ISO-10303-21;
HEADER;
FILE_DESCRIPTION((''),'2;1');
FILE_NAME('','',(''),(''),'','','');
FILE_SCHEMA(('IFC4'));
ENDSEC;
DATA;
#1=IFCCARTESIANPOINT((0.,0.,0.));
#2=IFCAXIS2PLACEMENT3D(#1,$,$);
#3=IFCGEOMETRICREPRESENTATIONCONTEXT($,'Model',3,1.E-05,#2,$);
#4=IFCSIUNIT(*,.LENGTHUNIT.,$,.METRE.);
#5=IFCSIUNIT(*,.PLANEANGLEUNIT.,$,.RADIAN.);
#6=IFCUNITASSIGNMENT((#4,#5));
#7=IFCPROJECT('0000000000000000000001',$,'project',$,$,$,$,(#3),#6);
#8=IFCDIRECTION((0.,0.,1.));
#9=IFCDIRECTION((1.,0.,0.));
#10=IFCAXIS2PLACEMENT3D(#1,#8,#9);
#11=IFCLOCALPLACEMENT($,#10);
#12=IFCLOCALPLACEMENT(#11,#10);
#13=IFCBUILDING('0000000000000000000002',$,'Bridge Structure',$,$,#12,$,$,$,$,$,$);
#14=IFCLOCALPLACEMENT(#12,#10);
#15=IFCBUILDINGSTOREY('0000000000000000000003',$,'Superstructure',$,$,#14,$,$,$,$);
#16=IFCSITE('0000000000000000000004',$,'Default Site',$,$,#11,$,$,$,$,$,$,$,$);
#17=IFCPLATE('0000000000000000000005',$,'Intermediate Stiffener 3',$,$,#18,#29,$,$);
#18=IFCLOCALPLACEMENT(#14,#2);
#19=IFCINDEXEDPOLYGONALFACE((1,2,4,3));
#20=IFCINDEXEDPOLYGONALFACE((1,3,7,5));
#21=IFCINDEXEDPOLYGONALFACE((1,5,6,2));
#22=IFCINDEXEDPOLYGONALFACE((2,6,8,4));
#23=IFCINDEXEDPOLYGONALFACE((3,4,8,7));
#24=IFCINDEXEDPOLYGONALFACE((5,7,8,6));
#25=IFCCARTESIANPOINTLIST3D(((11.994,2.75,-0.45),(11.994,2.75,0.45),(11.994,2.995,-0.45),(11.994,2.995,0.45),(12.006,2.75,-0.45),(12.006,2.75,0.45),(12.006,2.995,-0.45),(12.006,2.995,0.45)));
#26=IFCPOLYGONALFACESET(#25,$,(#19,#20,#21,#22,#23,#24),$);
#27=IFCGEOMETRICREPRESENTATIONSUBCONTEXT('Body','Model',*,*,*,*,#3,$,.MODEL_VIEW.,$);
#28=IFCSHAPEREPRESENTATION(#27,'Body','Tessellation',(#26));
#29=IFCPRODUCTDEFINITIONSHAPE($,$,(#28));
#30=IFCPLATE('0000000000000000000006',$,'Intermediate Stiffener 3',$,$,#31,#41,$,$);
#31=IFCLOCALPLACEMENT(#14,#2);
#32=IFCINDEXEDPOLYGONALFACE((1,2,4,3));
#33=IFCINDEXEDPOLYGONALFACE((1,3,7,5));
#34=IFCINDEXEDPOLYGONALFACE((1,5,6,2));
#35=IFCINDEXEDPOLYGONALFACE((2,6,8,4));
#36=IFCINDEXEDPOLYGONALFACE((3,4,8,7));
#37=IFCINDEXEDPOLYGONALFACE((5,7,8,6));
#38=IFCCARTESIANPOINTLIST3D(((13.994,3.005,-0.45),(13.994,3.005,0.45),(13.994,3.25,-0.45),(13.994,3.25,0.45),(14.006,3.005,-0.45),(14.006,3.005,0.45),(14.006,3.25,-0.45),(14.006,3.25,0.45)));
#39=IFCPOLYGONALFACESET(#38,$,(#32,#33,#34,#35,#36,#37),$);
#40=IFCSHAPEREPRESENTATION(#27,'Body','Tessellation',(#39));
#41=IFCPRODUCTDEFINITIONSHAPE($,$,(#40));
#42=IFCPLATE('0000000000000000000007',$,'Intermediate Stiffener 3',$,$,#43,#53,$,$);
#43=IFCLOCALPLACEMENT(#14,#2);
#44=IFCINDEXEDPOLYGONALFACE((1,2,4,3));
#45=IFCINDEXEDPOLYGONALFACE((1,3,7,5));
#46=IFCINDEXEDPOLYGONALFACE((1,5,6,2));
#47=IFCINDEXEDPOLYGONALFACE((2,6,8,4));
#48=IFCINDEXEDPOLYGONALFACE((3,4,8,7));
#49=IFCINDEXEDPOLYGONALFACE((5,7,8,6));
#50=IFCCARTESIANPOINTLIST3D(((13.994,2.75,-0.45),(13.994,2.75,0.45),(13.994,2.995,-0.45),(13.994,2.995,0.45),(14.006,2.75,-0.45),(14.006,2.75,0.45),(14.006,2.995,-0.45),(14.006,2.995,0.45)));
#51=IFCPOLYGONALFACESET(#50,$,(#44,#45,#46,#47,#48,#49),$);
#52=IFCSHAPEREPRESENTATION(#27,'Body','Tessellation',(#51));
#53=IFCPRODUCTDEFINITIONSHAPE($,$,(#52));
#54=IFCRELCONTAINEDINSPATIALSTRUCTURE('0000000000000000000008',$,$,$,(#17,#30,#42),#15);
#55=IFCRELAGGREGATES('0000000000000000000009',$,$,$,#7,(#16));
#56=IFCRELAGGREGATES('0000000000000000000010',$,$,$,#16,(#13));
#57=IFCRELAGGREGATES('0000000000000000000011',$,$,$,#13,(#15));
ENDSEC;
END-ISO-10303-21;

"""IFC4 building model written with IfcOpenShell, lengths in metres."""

from ifc_helpers import new_model, si_unit, frame, origin, origin_with_axes, origin_2d_with_axis, place, context, subcontext, project, spatial, rectangle, extrude, element, save


model = new_model("IFC4")

# Units and contexts
model_context = context("Model", 3, precision=1e-05, world=origin())
body_context = subcontext(model_context, "Body", "Model", "MODEL_VIEW")
ifc_project = project(units=[si_unit("LENGTHUNIT", "METRE"), si_unit("PLANEANGLEUNIT", "RADIAN")], contexts=[model_context])

# Site, building, storey
site_placement = place(None, origin_with_axes())
site = spatial("IfcSite", under=ifc_project, at=site_placement, Name="Default Site")
building_placement = place(site_placement, origin_with_axes())
building = spatial("IfcBuilding", under=site, at=building_placement, Name="Bridge Structure")
storey_placement = place(building_placement, origin_with_axes())
storey = spatial("IfcBuildingStorey", under=building, at=storey_placement, Name="Superstructure")

# Plates
for number, where, z_axis, x_axis, name in (
    (1, (12.0, 2.8725, -0.45), (0.0, 0.0, 1.0), (1.0, 0.0, 0.0), "Intermediate Stiffener 3"),
    (2, (14.0, 3.1275, -0.45), (0.0, 0.0, 1.0), (1.0, 0.0, 0.0), "Intermediate Stiffener 3"),
    (3, (14.0, 2.8725, -0.45), (0.0, 0.0, 1.0), (1.0, 0.0, 0.0), "Intermediate Stiffener 3"),
):
    element("IfcPlate", number, at=place(storey_placement, frame(where, z_axis=z_axis, x_axis=x_axis)), inside=storey, Name=name, context=body_context, shape_type="SweptSolid", body=[
        extrude(rectangle(XDim=0.012, YDim=0.245, at=origin_2d_with_axis()), origin_with_axes(), (0.0, 0.0, 1.0), 0.9),
    ])

save(model, "model.ifc")
